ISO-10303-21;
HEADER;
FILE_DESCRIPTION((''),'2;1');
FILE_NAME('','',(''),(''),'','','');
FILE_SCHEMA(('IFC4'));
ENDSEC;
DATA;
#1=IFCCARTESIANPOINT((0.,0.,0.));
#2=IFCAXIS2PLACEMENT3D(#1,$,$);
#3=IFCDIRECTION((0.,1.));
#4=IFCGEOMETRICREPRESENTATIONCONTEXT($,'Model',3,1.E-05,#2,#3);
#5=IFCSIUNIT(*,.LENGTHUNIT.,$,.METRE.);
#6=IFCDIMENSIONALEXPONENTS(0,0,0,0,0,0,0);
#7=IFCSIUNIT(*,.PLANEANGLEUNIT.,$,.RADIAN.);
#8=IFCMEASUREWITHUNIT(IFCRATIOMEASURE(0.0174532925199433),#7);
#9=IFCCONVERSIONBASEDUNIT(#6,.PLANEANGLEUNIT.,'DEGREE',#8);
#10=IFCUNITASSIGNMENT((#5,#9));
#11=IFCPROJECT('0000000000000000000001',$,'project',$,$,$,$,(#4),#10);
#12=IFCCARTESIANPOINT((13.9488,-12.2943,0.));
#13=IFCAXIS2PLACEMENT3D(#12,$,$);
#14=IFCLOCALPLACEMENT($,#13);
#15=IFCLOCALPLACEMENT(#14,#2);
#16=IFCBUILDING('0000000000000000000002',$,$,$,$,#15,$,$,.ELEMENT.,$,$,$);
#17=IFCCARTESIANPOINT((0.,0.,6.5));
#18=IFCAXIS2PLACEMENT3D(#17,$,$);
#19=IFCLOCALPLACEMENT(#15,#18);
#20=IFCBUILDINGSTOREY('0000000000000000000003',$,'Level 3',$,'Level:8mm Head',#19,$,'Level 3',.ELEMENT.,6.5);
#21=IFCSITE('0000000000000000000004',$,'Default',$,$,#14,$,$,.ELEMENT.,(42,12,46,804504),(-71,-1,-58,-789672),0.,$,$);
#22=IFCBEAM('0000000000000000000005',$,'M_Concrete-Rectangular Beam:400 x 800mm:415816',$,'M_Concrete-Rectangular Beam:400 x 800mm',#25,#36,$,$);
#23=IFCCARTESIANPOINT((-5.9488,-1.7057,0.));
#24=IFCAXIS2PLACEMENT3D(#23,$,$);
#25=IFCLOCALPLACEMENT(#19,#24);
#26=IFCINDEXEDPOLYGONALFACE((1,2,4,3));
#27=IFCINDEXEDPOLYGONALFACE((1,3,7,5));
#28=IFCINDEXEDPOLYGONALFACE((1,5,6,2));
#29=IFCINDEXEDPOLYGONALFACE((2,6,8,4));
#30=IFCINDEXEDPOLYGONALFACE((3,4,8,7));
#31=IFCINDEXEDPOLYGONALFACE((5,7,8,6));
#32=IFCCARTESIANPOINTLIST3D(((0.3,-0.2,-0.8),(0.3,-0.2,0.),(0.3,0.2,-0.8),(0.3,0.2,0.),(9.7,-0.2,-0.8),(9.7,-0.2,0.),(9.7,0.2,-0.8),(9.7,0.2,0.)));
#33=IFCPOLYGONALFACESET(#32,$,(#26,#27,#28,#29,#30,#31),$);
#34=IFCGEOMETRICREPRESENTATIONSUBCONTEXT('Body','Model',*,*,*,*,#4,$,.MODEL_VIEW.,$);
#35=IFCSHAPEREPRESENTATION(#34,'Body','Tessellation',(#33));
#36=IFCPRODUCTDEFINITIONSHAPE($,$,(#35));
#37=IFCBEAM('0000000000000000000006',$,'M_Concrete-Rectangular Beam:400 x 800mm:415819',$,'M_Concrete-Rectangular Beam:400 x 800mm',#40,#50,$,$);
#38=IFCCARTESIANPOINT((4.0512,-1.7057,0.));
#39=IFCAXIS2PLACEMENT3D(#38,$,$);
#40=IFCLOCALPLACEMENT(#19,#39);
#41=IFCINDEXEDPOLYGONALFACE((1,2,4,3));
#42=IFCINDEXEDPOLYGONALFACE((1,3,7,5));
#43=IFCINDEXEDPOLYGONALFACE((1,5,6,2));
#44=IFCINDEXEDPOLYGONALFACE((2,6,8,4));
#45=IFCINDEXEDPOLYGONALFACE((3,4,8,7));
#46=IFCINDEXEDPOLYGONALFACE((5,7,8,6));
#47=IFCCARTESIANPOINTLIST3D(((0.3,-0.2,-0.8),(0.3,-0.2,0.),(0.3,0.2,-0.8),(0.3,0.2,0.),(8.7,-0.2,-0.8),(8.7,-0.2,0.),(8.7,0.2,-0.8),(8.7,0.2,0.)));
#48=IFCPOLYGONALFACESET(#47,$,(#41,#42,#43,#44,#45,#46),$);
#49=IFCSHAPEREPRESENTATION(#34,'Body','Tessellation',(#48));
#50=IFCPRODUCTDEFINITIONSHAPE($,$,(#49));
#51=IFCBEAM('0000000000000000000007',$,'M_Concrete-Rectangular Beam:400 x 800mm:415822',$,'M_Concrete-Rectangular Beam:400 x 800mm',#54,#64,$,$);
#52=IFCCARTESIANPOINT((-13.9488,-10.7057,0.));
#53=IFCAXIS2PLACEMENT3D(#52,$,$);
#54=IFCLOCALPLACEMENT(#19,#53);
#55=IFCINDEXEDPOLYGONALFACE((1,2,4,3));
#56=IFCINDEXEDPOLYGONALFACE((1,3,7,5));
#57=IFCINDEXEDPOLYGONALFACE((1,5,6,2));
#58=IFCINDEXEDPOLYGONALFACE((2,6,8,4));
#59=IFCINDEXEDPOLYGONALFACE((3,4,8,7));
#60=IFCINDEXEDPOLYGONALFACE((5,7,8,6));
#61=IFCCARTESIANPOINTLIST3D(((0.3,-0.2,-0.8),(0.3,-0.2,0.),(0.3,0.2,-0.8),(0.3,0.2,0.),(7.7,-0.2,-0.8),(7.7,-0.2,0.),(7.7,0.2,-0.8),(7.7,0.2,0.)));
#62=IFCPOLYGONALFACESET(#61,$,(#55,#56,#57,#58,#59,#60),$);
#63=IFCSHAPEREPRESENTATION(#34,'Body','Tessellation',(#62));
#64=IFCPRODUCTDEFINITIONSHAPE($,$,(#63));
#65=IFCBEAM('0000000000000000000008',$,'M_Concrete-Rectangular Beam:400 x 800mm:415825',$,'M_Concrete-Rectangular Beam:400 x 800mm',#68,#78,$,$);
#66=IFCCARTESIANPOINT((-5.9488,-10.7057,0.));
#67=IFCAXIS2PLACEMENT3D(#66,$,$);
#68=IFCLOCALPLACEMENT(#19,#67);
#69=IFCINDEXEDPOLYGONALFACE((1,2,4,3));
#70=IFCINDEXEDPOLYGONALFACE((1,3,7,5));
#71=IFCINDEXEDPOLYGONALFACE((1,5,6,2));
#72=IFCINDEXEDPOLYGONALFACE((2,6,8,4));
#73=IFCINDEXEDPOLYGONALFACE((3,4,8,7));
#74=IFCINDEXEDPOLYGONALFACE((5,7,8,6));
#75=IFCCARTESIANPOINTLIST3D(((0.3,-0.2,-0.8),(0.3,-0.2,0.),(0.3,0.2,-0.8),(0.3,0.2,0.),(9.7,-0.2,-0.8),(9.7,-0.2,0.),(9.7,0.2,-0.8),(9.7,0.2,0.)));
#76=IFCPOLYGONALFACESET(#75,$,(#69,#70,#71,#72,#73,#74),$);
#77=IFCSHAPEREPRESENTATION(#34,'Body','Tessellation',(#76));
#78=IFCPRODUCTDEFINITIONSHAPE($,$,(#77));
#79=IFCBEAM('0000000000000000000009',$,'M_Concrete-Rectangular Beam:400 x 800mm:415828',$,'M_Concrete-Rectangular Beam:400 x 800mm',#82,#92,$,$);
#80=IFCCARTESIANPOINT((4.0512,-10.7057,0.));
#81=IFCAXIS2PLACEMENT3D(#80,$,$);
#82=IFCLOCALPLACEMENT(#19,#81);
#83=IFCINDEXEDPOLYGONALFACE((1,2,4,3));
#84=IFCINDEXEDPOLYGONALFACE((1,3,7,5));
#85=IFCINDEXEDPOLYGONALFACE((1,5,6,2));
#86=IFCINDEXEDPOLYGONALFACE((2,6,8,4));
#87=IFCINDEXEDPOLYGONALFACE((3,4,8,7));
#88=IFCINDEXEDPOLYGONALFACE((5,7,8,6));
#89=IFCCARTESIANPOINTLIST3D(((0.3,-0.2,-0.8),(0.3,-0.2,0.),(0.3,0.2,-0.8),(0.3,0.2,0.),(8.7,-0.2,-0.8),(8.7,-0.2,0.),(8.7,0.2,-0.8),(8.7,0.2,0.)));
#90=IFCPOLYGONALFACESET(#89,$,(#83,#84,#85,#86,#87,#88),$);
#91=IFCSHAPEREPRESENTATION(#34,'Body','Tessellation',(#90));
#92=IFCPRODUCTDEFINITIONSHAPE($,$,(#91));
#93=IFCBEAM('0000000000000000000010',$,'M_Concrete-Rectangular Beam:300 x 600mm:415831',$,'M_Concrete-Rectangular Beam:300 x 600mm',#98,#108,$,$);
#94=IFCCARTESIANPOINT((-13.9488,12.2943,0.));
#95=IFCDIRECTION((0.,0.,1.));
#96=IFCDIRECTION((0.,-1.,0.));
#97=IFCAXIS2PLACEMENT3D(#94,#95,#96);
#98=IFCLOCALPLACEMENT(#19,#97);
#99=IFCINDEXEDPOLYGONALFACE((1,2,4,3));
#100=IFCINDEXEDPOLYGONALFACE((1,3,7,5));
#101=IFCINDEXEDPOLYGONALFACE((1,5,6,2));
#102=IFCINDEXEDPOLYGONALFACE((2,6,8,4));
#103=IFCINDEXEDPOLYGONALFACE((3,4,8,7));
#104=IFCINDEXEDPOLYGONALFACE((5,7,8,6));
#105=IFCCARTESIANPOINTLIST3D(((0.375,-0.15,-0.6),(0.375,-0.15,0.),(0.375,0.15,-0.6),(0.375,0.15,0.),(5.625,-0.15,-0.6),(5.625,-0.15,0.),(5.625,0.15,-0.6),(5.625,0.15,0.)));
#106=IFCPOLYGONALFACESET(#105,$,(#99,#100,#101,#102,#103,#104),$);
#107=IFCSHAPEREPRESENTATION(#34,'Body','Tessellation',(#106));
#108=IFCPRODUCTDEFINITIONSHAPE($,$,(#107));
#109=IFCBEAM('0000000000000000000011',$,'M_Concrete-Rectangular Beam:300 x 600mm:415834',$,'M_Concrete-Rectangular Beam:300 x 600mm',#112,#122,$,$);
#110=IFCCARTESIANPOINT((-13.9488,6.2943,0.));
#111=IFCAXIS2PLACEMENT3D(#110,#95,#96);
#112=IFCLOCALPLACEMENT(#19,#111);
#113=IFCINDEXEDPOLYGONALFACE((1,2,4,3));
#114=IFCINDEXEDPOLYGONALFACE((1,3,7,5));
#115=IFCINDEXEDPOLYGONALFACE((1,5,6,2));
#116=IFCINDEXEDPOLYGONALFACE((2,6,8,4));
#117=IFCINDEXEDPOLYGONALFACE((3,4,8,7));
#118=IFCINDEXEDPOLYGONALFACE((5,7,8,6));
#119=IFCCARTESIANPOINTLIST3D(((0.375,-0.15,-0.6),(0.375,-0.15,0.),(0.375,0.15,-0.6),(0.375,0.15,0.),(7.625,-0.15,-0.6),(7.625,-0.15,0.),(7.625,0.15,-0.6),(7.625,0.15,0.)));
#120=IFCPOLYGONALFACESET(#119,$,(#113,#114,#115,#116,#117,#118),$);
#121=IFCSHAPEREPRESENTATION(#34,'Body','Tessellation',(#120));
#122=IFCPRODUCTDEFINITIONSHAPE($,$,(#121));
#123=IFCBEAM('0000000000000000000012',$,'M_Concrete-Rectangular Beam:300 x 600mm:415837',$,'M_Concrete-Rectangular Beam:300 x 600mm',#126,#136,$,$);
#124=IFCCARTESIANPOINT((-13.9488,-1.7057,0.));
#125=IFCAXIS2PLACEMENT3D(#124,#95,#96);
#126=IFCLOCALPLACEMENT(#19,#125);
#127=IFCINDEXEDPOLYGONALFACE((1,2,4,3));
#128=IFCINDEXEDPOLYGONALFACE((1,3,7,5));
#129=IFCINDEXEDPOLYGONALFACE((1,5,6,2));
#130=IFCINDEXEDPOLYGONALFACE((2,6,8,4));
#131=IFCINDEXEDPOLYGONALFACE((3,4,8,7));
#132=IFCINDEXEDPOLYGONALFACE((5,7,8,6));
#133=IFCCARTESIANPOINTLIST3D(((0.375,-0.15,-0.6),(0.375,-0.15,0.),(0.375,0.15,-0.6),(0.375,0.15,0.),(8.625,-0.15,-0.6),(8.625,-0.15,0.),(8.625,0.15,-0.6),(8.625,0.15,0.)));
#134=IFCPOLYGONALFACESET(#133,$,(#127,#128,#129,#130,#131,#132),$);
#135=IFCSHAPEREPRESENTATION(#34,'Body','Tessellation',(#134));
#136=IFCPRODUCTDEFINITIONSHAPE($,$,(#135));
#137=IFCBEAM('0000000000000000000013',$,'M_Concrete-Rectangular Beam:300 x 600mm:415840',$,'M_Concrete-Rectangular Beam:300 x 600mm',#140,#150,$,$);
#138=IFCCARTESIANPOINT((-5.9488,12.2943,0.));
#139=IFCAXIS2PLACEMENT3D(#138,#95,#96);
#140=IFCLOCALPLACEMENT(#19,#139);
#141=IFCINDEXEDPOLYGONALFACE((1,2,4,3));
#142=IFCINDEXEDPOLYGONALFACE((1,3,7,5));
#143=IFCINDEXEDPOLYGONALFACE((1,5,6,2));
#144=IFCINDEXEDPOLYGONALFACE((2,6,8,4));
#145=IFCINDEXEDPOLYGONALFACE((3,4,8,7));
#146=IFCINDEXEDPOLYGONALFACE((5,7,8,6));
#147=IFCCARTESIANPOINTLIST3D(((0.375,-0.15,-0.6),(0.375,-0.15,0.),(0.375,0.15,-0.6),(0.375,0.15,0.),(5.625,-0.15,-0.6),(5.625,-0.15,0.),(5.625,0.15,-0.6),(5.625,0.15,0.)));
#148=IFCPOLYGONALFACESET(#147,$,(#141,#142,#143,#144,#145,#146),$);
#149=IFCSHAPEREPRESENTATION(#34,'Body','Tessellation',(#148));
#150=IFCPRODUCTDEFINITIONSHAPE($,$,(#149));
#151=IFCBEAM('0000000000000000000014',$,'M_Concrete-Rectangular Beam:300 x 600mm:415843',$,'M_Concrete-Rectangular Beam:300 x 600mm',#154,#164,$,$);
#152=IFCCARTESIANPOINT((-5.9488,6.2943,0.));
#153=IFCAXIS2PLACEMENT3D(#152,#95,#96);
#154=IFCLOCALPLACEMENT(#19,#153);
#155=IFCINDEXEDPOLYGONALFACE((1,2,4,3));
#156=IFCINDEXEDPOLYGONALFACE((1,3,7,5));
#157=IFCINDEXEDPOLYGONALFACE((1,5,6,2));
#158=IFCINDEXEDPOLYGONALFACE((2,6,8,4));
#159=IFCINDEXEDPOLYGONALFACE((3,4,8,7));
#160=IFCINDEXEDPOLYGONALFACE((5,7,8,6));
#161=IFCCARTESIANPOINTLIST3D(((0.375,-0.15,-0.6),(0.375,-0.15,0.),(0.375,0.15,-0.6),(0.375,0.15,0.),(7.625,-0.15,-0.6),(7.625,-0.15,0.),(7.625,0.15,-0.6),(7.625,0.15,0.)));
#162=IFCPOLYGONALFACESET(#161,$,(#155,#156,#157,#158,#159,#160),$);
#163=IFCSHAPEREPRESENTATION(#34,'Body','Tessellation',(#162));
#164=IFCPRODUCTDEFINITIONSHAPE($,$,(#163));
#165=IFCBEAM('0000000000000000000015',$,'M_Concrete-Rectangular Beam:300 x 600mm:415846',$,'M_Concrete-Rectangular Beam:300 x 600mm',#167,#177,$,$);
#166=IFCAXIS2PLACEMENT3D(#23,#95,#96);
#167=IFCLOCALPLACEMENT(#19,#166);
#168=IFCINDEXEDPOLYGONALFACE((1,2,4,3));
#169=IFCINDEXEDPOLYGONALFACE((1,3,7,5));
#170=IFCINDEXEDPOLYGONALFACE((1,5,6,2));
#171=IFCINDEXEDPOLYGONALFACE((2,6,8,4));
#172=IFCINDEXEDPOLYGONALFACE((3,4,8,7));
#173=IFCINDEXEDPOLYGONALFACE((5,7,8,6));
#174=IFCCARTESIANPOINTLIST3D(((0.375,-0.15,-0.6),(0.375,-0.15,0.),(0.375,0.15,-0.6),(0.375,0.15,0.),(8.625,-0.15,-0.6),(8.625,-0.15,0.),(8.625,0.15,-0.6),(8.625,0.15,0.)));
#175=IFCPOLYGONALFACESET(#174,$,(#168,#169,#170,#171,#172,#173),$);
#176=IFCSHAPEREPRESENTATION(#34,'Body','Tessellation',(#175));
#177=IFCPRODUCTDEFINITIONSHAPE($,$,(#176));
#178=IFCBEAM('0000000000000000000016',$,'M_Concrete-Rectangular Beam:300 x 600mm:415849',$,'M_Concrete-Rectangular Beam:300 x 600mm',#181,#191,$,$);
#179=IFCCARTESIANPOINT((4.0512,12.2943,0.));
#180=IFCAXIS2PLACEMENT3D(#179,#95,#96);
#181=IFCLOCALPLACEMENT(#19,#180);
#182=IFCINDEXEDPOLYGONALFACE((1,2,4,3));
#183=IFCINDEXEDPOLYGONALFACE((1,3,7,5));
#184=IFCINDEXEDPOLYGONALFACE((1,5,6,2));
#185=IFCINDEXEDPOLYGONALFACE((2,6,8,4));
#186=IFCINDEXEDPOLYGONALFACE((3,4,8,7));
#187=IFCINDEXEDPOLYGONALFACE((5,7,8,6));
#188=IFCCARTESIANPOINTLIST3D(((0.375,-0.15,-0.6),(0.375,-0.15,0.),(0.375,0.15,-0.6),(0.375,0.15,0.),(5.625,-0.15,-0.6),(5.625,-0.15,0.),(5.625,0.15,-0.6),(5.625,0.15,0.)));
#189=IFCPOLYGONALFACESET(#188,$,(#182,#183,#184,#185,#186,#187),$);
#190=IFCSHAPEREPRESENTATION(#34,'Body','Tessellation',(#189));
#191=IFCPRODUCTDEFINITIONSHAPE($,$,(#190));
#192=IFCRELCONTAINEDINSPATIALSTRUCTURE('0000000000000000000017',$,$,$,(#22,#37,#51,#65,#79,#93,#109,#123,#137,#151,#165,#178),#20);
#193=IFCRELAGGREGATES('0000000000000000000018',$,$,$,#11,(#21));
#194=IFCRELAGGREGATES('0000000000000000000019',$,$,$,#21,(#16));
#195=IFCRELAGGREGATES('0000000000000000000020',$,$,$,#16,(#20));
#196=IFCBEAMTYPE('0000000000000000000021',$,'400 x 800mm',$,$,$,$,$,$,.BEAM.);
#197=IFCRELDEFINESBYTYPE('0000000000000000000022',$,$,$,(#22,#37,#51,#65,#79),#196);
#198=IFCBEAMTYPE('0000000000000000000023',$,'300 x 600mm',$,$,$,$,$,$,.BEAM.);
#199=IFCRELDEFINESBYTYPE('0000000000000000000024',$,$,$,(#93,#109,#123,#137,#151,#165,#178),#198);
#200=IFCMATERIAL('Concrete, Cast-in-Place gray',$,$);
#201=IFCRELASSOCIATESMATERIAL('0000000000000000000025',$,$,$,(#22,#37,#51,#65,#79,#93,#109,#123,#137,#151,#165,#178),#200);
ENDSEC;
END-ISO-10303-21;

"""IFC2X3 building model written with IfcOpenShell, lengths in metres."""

from ifc_helpers import new_model, entity, si_unit, converted_unit, direction, frame, frame_2d, origin, place, context, subcontext, project, spatial, rectangle, extrude, material, type_object, element, save


model = new_model("IFC2X3")

# Units and contexts
model_context = context("Model", 3, precision=1e-05, world=origin(), true_north=direction((0.0, 1.0)))
body_context = subcontext(model_context, "Body", "Model", "MODEL_VIEW")
ifc_project = project(units=[si_unit("LENGTHUNIT", "METRE"), converted_unit("PLANEANGLEUNIT", "DEGREE", entity("IfcRatioMeasure", 0.0174532925199433), si_unit("PLANEANGLEUNIT", "RADIAN"), dimensions=[0, 0, 0, 0, 0, 0, 0])], contexts=[model_context])

# Site, building, storey
site_placement = place(None, frame((13.9488, -12.2943, 0.0)))
site = spatial("IfcSite", under=ifc_project, at=site_placement, Name="Default", CompositionType="ELEMENT", RefLatitude=(42, 12, 46, 804504), RefLongitude=(-71, -1, -58, -789672), RefElevation=0.0)
building_placement = place(site_placement, origin())
building = spatial("IfcBuilding", under=site, at=building_placement, CompositionType="ELEMENT")
storey_placement = place(building_placement, frame((0.0, 0.0, 6.5)))
storey = spatial("IfcBuildingStorey", under=building, at=storey_placement, Name="Level 3", ObjectType="Level:8mm Head", LongName="Level 3", CompositionType="ELEMENT", Elevation=6.5)

# Shared definitions
ifc_material = material(Name="Concrete, Cast-in-Place gray")

# Beams
beam_type_1 = type_object("IfcBeamType", Name="400 x 800mm", PredefinedType="BEAM")
beam_1_placement = place(storey_placement, frame((-5.9488, -1.7057, 0.0)))
element("IfcBeam", 1, at=beam_1_placement, inside=storey, type_object=beam_type_1, material=ifc_material, Name="M_Concrete-Rectangular Beam:400 x 800mm:415816", ObjectType="M_Concrete-Rectangular Beam:400 x 800mm", context=body_context, shape_type="SweptSolid", body=[
    extrude(rectangle(XDim=0.8, YDim=0.4, at=frame_2d((0.0, 0.0), x_axis=(1.0, 0.0))), frame((0.3, 0.0, -0.4), z_axis=(1.0, 0.0, 0.0), x_axis=(0.0, 0.0, -1.0)), (0.0, 0.0, 1.0), 9.4),
])
beam_2_placement = place(storey_placement, frame((4.0512, -1.7057, 0.0)))
element("IfcBeam", 2, at=beam_2_placement, inside=storey, type_object=beam_type_1, material=ifc_material, Name="M_Concrete-Rectangular Beam:400 x 800mm:415819", ObjectType="M_Concrete-Rectangular Beam:400 x 800mm", context=body_context, shape_type="SweptSolid", body=[
    extrude(rectangle(XDim=0.8, YDim=0.4, at=frame_2d((0.0, 0.0), x_axis=(1.0, 0.0))), frame((0.3, 0.0, -0.4), z_axis=(1.0, 0.0, 0.0), x_axis=(0.0, 0.0, -1.0)), (0.0, 0.0, 1.0), 8.4),
])
beam_3_placement = place(storey_placement, frame((-13.9488, -10.7057, 0.0)))
element("IfcBeam", 3, at=beam_3_placement, inside=storey, type_object=beam_type_1, material=ifc_material, Name="M_Concrete-Rectangular Beam:400 x 800mm:415822", ObjectType="M_Concrete-Rectangular Beam:400 x 800mm", context=body_context, shape_type="SweptSolid", body=[
    extrude(rectangle(XDim=0.8, YDim=0.4, at=frame_2d((0.0, 0.0), x_axis=(1.0, 0.0))), frame((0.3, 0.0, -0.4), z_axis=(1.0, 0.0, 0.0), x_axis=(0.0, 0.0, -1.0)), (0.0, 0.0, 1.0), 7.4),
])
beam_4_placement = place(storey_placement, frame((-5.9488, -10.7057, 0.0)))
element("IfcBeam", 4, at=beam_4_placement, inside=storey, type_object=beam_type_1, material=ifc_material, Name="M_Concrete-Rectangular Beam:400 x 800mm:415825", ObjectType="M_Concrete-Rectangular Beam:400 x 800mm", context=body_context, shape_type="SweptSolid", body=[
    extrude(rectangle(XDim=0.8, YDim=0.4, at=frame_2d((0.0, 0.0), x_axis=(1.0, 0.0))), frame((0.3, 0.0, -0.4), z_axis=(1.0, 0.0, 0.0), x_axis=(0.0, 0.0, -1.0)), (0.0, 0.0, 1.0), 9.4),
])
beam_5_placement = place(storey_placement, frame((4.0512, -10.7057, 0.0)))
element("IfcBeam", 5, at=beam_5_placement, inside=storey, type_object=beam_type_1, material=ifc_material, Name="M_Concrete-Rectangular Beam:400 x 800mm:415828", ObjectType="M_Concrete-Rectangular Beam:400 x 800mm", context=body_context, shape_type="SweptSolid", body=[
    extrude(rectangle(XDim=0.8, YDim=0.4, at=frame_2d((0.0, 0.0), x_axis=(1.0, 0.0))), frame((0.3, 0.0, -0.4), z_axis=(1.0, 0.0, 0.0), x_axis=(0.0, 0.0, -1.0)), (0.0, 0.0, 1.0), 8.4),
])
beam_type_2 = type_object("IfcBeamType", Name="300 x 600mm", PredefinedType="BEAM")
beam_6_placement = place(storey_placement, frame((-13.9488, 12.2943, 0.0), z_axis=(0.0, 0.0, 1.0), x_axis=(0.0, -1.0, 0.0)))
element("IfcBeam", 6, at=beam_6_placement, inside=storey, type_object=beam_type_2, material=ifc_material, Name="M_Concrete-Rectangular Beam:300 x 600mm:415831", ObjectType="M_Concrete-Rectangular Beam:300 x 600mm", context=body_context, shape_type="SweptSolid", body=[
    extrude(rectangle(XDim=0.6, YDim=0.3, at=frame_2d((0.0, 0.0), x_axis=(1.0, 0.0))), frame((0.375, 0.0, -0.3), z_axis=(1.0, 0.0, 0.0), x_axis=(0.0, 0.0, -1.0)), (0.0, 0.0, 1.0), 5.25),
])
beam_7_placement = place(storey_placement, frame((-13.9488, 6.2943, 0.0), z_axis=(0.0, 0.0, 1.0), x_axis=(0.0, -1.0, 0.0)))
element("IfcBeam", 7, at=beam_7_placement, inside=storey, type_object=beam_type_2, material=ifc_material, Name="M_Concrete-Rectangular Beam:300 x 600mm:415834", ObjectType="M_Concrete-Rectangular Beam:300 x 600mm", context=body_context, shape_type="SweptSolid", body=[
    extrude(rectangle(XDim=0.6, YDim=0.3, at=frame_2d((0.0, 0.0), x_axis=(1.0, 0.0))), frame((0.375, 0.0, -0.3), z_axis=(1.0, 0.0, 0.0), x_axis=(0.0, 0.0, -1.0)), (0.0, 0.0, 1.0), 7.25),
])
beam_8_placement = place(storey_placement, frame((-13.9488, -1.7057, 0.0), z_axis=(0.0, 0.0, 1.0), x_axis=(0.0, -1.0, 0.0)))
element("IfcBeam", 8, at=beam_8_placement, inside=storey, type_object=beam_type_2, material=ifc_material, Name="M_Concrete-Rectangular Beam:300 x 600mm:415837", ObjectType="M_Concrete-Rectangular Beam:300 x 600mm", context=body_context, shape_type="SweptSolid", body=[
    extrude(rectangle(XDim=0.6, YDim=0.3, at=frame_2d((0.0, 0.0), x_axis=(1.0, 0.0))), frame((0.375, 0.0, -0.3), z_axis=(1.0, 0.0, 0.0), x_axis=(0.0, 0.0, -1.0)), (0.0, 0.0, 1.0), 8.25),
])
beam_9_placement = place(storey_placement, frame((-5.9488, 12.2943, 0.0), z_axis=(0.0, 0.0, 1.0), x_axis=(0.0, -1.0, 0.0)))
element("IfcBeam", 9, at=beam_9_placement, inside=storey, type_object=beam_type_2, material=ifc_material, Name="M_Concrete-Rectangular Beam:300 x 600mm:415840", ObjectType="M_Concrete-Rectangular Beam:300 x 600mm", context=body_context, shape_type="SweptSolid", body=[
    extrude(rectangle(XDim=0.6, YDim=0.3, at=frame_2d((0.0, 0.0), x_axis=(1.0, 0.0))), frame((0.375, 0.0, -0.3), z_axis=(1.0, 0.0, 0.0), x_axis=(0.0, 0.0, -1.0)), (0.0, 0.0, 1.0), 5.25),
])
beam_10_placement = place(storey_placement, frame((-5.9488, 6.2943, 0.0), z_axis=(0.0, 0.0, 1.0), x_axis=(0.0, -1.0, 0.0)))
element("IfcBeam", 10, at=beam_10_placement, inside=storey, type_object=beam_type_2, material=ifc_material, Name="M_Concrete-Rectangular Beam:300 x 600mm:415843", ObjectType="M_Concrete-Rectangular Beam:300 x 600mm", context=body_context, shape_type="SweptSolid", body=[
    extrude(rectangle(XDim=0.6, YDim=0.3, at=frame_2d((0.0, 0.0), x_axis=(1.0, 0.0))), frame((0.375, 0.0, -0.3), z_axis=(1.0, 0.0, 0.0), x_axis=(0.0, 0.0, -1.0)), (0.0, 0.0, 1.0), 7.25),
])
beam_11_placement = place(storey_placement, frame((-5.9488, -1.7057, 0.0), z_axis=(0.0, 0.0, 1.0), x_axis=(0.0, -1.0, 0.0)))
element("IfcBeam", 11, at=beam_11_placement, inside=storey, type_object=beam_type_2, material=ifc_material, Name="M_Concrete-Rectangular Beam:300 x 600mm:415846", ObjectType="M_Concrete-Rectangular Beam:300 x 600mm", context=body_context, shape_type="SweptSolid", body=[
    extrude(rectangle(XDim=0.6, YDim=0.3, at=frame_2d((0.0, 0.0), x_axis=(1.0, 0.0))), frame((0.375, 0.0, -0.3), z_axis=(1.0, 0.0, 0.0), x_axis=(0.0, 0.0, -1.0)), (0.0, 0.0, 1.0), 8.25),
])
beam_12_placement = place(storey_placement, frame((4.0512, 12.2943, 0.0), z_axis=(0.0, 0.0, 1.0), x_axis=(0.0, -1.0, 0.0)))
element("IfcBeam", 12, at=beam_12_placement, inside=storey, type_object=beam_type_2, material=ifc_material, Name="M_Concrete-Rectangular Beam:300 x 600mm:415849", ObjectType="M_Concrete-Rectangular Beam:300 x 600mm", context=body_context, shape_type="SweptSolid", body=[
    extrude(rectangle(XDim=0.6, YDim=0.3, at=frame_2d((0.0, 0.0), x_axis=(1.0, 0.0))), frame((0.375, 0.0, -0.3), z_axis=(1.0, 0.0, 0.0), x_axis=(0.0, 0.0, -1.0)), (0.0, 0.0, 1.0), 5.25),
])

save(model, "model.ifc")
